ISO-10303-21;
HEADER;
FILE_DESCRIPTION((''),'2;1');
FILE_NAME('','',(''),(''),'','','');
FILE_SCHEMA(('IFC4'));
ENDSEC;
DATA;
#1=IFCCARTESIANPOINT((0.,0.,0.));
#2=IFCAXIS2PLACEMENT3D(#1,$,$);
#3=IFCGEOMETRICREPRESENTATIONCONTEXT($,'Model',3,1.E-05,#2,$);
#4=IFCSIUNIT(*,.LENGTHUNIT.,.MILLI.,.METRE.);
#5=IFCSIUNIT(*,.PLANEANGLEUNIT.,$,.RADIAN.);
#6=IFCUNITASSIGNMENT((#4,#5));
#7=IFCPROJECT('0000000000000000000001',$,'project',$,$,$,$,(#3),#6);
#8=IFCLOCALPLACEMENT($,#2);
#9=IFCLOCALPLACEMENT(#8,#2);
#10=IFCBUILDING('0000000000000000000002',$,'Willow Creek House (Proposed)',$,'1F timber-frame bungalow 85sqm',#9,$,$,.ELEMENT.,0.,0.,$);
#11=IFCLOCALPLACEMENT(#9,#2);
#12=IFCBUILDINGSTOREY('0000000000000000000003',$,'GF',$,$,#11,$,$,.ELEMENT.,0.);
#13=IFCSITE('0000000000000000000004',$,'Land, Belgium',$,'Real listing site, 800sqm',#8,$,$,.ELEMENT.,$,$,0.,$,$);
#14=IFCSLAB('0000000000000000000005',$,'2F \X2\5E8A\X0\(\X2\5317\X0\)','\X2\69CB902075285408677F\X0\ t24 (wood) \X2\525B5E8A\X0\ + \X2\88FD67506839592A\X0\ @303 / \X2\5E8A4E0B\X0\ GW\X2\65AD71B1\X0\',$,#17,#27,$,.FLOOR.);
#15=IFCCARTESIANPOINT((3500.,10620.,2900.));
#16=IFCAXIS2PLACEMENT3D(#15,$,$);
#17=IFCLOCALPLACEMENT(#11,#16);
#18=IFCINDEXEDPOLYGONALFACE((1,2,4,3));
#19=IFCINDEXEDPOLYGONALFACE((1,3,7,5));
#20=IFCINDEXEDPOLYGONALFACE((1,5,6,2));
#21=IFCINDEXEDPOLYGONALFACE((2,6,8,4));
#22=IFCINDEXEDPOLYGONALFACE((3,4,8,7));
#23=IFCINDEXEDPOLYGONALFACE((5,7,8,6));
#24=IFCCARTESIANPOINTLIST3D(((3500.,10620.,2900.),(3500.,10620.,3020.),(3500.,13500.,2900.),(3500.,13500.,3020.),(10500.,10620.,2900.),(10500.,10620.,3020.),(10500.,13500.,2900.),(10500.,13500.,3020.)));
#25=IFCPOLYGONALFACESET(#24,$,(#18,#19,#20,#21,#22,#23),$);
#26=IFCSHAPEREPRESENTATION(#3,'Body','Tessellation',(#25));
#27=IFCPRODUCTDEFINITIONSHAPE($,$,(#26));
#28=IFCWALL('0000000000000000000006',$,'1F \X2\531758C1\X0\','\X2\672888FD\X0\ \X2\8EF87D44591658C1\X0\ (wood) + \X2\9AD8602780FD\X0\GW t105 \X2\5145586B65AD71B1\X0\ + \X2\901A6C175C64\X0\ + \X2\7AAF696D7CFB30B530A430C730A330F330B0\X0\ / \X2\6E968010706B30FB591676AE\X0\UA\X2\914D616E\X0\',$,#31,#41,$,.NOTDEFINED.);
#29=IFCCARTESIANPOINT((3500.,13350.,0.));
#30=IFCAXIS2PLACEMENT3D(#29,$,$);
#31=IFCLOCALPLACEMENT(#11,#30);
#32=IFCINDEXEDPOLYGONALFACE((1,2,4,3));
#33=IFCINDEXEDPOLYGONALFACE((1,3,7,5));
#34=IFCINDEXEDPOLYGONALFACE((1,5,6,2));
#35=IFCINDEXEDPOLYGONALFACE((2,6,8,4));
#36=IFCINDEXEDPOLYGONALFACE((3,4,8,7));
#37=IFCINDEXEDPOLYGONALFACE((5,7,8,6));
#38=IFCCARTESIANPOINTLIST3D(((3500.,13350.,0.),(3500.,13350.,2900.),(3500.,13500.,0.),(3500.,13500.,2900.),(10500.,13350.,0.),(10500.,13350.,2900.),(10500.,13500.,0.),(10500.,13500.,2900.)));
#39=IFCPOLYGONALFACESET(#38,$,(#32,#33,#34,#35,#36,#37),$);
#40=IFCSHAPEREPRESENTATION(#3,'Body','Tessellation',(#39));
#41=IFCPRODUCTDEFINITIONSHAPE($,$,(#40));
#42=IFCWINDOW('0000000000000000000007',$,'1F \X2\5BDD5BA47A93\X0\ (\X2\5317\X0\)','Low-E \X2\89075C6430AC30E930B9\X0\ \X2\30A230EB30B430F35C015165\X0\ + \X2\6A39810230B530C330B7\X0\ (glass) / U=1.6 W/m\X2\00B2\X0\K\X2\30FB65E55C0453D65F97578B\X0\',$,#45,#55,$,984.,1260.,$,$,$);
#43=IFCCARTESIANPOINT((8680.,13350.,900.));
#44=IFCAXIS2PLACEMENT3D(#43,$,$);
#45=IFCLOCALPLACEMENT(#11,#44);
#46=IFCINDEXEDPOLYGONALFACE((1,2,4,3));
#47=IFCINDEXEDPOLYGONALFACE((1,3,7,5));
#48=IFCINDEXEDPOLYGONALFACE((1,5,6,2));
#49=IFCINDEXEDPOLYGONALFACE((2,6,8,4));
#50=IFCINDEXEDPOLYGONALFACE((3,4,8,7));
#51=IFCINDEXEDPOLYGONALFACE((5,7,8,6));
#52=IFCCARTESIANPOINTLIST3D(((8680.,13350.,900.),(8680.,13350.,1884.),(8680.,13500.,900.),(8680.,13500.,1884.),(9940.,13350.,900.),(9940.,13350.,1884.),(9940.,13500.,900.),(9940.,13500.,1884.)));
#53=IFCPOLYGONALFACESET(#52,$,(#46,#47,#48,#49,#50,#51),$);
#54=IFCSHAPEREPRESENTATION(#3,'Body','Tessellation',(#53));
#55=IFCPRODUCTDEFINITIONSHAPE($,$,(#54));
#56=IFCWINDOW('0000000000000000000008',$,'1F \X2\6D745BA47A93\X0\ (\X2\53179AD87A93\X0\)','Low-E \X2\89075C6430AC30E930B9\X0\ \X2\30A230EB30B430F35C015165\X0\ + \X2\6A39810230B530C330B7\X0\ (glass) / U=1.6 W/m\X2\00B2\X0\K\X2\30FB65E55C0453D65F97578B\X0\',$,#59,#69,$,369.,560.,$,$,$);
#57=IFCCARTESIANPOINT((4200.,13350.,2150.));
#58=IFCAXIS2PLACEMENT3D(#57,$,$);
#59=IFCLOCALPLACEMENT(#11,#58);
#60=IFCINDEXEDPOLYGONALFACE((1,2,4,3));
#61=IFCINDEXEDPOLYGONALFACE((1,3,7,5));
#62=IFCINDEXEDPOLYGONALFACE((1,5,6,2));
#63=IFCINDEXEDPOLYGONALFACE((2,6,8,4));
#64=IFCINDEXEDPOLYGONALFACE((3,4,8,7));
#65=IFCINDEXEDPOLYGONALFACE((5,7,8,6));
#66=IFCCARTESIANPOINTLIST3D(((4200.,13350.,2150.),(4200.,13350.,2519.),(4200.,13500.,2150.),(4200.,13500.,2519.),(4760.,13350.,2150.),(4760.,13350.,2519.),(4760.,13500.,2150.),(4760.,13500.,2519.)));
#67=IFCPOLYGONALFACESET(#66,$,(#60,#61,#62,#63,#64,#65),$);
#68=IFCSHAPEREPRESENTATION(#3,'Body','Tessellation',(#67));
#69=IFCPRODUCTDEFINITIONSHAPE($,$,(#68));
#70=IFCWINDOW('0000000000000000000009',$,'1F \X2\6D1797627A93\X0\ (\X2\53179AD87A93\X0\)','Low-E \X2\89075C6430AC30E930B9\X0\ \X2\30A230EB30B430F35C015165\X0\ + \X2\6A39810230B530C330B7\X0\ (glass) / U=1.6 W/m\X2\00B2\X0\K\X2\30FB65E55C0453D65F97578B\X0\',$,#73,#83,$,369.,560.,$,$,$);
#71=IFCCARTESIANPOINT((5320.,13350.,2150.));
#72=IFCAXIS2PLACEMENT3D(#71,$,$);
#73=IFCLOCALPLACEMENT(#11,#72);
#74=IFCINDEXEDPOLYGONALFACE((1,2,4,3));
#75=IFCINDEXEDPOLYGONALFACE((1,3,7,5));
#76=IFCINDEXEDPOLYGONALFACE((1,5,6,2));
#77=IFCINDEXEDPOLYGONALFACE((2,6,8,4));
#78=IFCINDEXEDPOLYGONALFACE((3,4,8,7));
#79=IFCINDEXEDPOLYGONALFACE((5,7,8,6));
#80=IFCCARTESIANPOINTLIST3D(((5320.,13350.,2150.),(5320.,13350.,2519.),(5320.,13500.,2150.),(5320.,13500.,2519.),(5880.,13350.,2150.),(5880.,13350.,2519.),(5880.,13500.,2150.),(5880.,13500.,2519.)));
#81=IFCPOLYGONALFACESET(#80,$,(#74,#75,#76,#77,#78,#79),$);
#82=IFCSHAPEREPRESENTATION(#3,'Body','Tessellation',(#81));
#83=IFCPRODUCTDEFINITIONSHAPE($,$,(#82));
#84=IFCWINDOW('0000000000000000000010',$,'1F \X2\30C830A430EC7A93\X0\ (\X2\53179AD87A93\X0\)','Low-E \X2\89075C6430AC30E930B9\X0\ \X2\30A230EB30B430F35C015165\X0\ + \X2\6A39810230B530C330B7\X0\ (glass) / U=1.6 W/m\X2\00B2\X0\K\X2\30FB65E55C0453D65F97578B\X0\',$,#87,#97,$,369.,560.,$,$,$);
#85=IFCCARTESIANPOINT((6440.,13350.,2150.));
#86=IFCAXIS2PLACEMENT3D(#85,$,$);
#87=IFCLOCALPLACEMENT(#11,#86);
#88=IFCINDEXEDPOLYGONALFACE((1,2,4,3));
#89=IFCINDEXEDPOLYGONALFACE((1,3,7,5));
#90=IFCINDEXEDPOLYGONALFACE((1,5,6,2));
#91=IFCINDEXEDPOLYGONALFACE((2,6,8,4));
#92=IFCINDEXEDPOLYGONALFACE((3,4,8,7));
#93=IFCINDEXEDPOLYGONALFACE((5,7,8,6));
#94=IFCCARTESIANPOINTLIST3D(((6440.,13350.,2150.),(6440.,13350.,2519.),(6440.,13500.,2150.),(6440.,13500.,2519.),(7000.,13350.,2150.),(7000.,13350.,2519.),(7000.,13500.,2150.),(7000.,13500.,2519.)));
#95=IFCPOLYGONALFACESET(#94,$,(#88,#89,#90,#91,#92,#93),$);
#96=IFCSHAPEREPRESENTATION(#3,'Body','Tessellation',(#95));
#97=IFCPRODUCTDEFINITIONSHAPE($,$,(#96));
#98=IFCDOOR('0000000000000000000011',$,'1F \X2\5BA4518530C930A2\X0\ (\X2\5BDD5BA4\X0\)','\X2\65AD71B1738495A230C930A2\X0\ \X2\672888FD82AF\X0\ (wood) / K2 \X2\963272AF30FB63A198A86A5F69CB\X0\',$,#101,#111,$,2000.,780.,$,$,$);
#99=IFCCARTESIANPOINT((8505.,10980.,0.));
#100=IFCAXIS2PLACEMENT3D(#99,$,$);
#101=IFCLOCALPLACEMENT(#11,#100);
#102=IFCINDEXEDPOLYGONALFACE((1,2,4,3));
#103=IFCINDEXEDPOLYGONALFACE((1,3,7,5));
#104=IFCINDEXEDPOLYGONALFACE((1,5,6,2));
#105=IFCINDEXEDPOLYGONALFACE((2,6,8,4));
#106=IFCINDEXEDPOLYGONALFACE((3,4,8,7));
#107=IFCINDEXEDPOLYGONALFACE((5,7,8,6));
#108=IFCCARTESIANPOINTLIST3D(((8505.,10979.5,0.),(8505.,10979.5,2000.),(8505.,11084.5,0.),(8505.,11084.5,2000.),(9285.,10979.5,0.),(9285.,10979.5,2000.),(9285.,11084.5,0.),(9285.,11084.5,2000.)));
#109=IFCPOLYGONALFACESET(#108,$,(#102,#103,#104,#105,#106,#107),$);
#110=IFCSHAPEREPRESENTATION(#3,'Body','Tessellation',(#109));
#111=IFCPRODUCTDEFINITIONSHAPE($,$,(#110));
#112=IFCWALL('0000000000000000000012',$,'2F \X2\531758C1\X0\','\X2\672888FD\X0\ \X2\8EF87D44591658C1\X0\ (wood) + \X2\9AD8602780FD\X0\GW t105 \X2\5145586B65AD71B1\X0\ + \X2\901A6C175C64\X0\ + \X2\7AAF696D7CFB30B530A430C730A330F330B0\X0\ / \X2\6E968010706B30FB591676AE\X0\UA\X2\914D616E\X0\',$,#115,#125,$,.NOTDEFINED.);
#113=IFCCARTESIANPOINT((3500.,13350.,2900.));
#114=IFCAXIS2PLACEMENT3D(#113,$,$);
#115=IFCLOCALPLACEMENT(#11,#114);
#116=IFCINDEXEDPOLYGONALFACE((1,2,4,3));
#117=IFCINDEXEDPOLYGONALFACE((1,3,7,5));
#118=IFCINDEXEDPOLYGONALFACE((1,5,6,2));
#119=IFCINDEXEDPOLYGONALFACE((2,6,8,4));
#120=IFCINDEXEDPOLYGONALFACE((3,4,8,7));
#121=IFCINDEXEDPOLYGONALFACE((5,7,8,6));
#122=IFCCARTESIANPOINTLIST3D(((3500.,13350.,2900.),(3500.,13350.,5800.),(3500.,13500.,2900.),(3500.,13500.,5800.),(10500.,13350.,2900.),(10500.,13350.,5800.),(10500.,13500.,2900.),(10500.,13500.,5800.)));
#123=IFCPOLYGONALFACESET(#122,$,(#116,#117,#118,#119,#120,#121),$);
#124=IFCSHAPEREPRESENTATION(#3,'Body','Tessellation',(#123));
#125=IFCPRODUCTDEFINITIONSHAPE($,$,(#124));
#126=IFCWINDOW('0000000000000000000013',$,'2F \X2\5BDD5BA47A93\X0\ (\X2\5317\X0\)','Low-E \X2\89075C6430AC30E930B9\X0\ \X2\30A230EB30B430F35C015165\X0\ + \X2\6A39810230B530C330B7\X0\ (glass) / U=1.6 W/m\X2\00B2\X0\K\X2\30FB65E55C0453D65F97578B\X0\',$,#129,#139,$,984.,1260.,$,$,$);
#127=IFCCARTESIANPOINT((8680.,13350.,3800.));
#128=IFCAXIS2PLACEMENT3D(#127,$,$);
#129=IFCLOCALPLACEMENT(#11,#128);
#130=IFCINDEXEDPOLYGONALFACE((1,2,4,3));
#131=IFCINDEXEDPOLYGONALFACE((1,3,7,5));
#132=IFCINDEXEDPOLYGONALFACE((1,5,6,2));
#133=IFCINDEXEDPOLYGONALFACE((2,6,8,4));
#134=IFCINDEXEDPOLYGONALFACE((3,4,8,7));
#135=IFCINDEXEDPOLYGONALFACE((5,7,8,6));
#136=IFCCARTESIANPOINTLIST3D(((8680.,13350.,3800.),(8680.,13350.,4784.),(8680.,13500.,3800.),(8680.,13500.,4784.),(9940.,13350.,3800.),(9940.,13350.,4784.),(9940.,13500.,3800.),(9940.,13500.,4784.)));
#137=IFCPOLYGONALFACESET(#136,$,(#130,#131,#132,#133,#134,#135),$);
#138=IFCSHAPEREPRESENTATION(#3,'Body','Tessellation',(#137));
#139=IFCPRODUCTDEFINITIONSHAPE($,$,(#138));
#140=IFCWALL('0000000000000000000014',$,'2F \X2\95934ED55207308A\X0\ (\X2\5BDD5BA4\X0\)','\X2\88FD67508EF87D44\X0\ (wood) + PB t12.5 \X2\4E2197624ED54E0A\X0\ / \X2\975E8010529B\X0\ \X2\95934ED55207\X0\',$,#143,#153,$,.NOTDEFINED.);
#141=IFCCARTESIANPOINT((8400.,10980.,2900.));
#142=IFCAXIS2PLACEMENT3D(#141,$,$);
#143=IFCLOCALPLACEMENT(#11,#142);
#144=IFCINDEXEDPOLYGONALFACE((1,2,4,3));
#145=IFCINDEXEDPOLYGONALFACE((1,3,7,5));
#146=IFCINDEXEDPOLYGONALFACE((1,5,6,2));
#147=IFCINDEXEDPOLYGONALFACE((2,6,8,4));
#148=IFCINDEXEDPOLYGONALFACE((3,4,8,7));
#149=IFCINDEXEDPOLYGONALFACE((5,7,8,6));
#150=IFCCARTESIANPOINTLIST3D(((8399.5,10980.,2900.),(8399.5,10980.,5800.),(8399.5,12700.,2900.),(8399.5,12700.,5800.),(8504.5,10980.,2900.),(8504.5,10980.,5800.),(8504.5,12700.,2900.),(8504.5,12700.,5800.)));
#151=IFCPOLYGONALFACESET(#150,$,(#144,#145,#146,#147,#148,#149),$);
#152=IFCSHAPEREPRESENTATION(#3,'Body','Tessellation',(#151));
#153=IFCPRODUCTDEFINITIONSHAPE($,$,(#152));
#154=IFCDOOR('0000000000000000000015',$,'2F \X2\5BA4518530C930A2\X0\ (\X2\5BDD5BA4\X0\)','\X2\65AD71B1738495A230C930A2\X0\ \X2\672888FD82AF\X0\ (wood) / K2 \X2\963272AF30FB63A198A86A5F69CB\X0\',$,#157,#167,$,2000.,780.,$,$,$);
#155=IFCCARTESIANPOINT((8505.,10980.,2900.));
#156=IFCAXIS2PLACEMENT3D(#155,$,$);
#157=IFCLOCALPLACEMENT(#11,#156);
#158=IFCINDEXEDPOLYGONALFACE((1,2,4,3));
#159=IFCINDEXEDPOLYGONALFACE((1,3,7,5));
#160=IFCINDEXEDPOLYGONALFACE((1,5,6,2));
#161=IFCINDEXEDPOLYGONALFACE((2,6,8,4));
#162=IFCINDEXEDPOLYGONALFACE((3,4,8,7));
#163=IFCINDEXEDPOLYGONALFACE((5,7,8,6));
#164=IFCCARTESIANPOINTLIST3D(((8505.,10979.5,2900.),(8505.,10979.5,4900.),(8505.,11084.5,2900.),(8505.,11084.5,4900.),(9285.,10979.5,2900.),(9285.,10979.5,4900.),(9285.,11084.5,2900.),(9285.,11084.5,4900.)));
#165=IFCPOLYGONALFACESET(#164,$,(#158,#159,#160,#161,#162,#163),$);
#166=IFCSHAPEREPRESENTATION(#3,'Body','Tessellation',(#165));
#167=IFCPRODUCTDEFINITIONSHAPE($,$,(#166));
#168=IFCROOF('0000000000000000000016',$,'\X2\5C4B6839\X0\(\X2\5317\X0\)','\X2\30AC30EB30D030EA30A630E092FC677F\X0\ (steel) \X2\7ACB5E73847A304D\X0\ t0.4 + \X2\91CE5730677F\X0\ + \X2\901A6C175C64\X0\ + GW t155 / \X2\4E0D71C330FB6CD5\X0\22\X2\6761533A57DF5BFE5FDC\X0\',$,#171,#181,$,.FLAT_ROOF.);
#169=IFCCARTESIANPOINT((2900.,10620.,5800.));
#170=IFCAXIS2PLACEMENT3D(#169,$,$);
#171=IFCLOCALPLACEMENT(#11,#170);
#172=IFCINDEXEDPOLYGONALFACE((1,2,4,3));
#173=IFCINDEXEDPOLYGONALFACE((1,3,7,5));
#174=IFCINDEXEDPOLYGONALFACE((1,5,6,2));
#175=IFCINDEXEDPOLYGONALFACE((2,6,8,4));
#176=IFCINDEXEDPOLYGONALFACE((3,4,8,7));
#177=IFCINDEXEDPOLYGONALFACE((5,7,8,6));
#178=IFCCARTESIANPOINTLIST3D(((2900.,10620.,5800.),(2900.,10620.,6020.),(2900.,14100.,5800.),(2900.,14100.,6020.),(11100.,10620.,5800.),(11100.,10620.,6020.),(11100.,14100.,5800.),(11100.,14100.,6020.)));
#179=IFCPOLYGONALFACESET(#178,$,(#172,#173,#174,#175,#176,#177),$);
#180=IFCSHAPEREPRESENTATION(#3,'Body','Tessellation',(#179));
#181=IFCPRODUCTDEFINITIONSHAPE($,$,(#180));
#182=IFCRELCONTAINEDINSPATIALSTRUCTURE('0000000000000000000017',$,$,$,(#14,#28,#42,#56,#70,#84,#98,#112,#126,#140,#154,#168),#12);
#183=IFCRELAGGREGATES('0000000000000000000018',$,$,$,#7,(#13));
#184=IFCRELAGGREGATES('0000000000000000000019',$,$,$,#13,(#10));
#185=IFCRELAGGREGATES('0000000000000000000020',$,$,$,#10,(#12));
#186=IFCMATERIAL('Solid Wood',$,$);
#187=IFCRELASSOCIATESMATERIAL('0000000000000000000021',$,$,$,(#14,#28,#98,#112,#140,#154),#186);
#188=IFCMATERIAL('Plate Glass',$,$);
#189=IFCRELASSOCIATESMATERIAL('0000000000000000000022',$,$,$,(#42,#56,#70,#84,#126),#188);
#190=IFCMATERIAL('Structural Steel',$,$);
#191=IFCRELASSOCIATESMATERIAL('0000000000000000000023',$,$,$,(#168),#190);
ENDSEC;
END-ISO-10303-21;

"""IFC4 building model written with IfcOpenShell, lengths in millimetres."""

from ifc_helpers import new_model, si_unit, frame, frame_2d, origin, place, context, project, spatial, rectangle, extrude, material, element, fill, save


model = new_model("IFC4")

# Units and contexts
model_context = context("Model", 3, precision=1e-05, world=origin())
ifc_project = project(units=[si_unit("LENGTHUNIT", "METRE", prefix="MILLI"), si_unit("PLANEANGLEUNIT", "RADIAN")], contexts=[model_context])

# Site, building, storey
site_placement = place(None, origin())
site = spatial("IfcSite", under=ifc_project, at=site_placement, Name="Land, Belgium", ObjectType="Real listing site, 800sqm", CompositionType="ELEMENT", RefElevation=0.0)
building_placement = place(site_placement, origin())
building = spatial("IfcBuilding", under=site, at=building_placement, Name="Willow Creek House (Proposed)", ObjectType="1F timber-frame bungalow 85sqm", CompositionType="ELEMENT", ElevationOfRefHeight=0.0, ElevationOfTerrain=0.0)
storey_placement = place(building_placement, origin())
storey = spatial("IfcBuildingStorey", under=building, at=storey_placement, Name="GF", CompositionType="ELEMENT", Elevation=0.0)

# Slab
ifc_material_1 = material(Name="Solid Wood")
slab_placement = place(storey_placement, frame((3500.0, 10620.0, 2900.0)))
element("IfcSlab", 1, at=slab_placement, inside=storey, material=ifc_material_1, Name="2F 床(北)", Description="構造用合板 t24 (wood) 剛床 + 製材根太 @303 / 床下 GW断熱", PredefinedType="FLOOR", context=model_context, shape_type="SweptSolid", body=[
    extrude(rectangle(XDim=7000.0, YDim=2880.0, at=frame_2d((3500.0, 1440.0))), frame((3500.0, 10620.0, 2900.0)), (0.0, 0.0, 1.0), 120.0),
])

# Wall, openings, windows
wall_1_placement = place(storey_placement, frame((3500.0, 13350.0, 0.0)))
wall_1 = element("IfcWall", 2, at=wall_1_placement, inside=storey, material=ifc_material_1, Name="1F 北壁", Description="木製 軸組外壁 (wood) + 高性能GW t105 充填断熱 + 通気層 + 窯業系サイディング / 準耐火・外皮UA配慮", PredefinedType="NOTDEFINED", context=model_context, shape_type="SweptSolid", body=[
    extrude(rectangle(XDim=7000.0, YDim=150.0, at=frame_2d((3500.0, 75.0))), frame((3500.0, 13350.0, 0.0)), (0.0, 0.0, 1.0), 2900.0),
])
opening_1_placement = place(storey_placement, frame((8680.0, 13350.0, 900.0)))
opening_1 = element("IfcOpeningElement", 3, at=opening_1_placement, cuts=wall_1, PredefinedType="NOTDEFINED", context=model_context, shape_type="SweptSolid", body=[
    extrude(rectangle(XDim=1260.0, YDim=150.0, at=frame_2d((630.0, 75.0))), frame((8680.0, 13350.0, 900.0)), (0.0, 0.0, 1.0), 984.0),
])
opening_2_placement = place(storey_placement, frame((4200.0, 13350.0, 2150.0)))
opening_2 = element("IfcOpeningElement", 4, at=opening_2_placement, cuts=wall_1, PredefinedType="NOTDEFINED", context=model_context, shape_type="SweptSolid", body=[
    extrude(rectangle(XDim=560.0, YDim=150.0, at=frame_2d((280.0, 75.0))), frame((4200.0, 13350.0, 2150.0)), (0.0, 0.0, 1.0), 369.0),
])
opening_3_placement = place(storey_placement, frame((5320.0, 13350.0, 2150.0)))
opening_3 = element("IfcOpeningElement", 5, at=opening_3_placement, cuts=wall_1, PredefinedType="NOTDEFINED", context=model_context, shape_type="SweptSolid", body=[
    extrude(rectangle(XDim=560.0, YDim=150.0, at=frame_2d((280.0, 75.0))), frame((5320.0, 13350.0, 2150.0)), (0.0, 0.0, 1.0), 369.0),
])
opening_4_placement = place(storey_placement, frame((6440.0, 13350.0, 2150.0)))
opening_4 = element("IfcOpeningElement", 6, at=opening_4_placement, cuts=wall_1, PredefinedType="NOTDEFINED", context=model_context, shape_type="SweptSolid", body=[
    extrude(rectangle(XDim=560.0, YDim=150.0, at=frame_2d((280.0, 75.0))), frame((6440.0, 13350.0, 2150.0)), (0.0, 0.0, 1.0), 369.0),
])
ifc_material_2 = material(Name="Plate Glass")
window_1_placement = place(storey_placement, frame((8680.0, 13350.0, 900.0)))
window_1 = element("IfcWindow", 7, at=window_1_placement, inside=storey, material=ifc_material_2, Name="1F 寝室窓 (北)", Description="Low-E 複層ガラス アルゴン封入 + 樹脂サッシ (glass) / U=1.6 W/m²K・日射取得型", OverallHeight=984.0, OverallWidth=1260.0, context=model_context, shape_type="SweptSolid", body=[
    extrude(rectangle(XDim=1260.0, YDim=150.0, at=frame_2d((630.0, 75.0))), frame((8680.0, 13350.0, 900.0)), (0.0, 0.0, 1.0), 984.0),
])
fill(opening_1, window_1)
window_2_placement = place(storey_placement, frame((4200.0, 13350.0, 2150.0)))
window_2 = element("IfcWindow", 8, at=window_2_placement, inside=storey, material=ifc_material_2, Name="1F 浴室窓 (北高窓)", Description="Low-E 複層ガラス アルゴン封入 + 樹脂サッシ (glass) / U=1.6 W/m²K・日射取得型", OverallHeight=369.0, OverallWidth=560.0, context=model_context, shape_type="SweptSolid", body=[
    extrude(rectangle(XDim=560.0, YDim=150.0, at=frame_2d((280.0, 75.0))), frame((4200.0, 13350.0, 2150.0)), (0.0, 0.0, 1.0), 369.0),
])
fill(opening_2, window_2)
window_3_placement = place(storey_placement, frame((5320.0, 13350.0, 2150.0)))
window_3 = element("IfcWindow", 9, at=window_3_placement, inside=storey, material=ifc_material_2, Name="1F 洗面窓 (北高窓)", Description="Low-E 複層ガラス アルゴン封入 + 樹脂サッシ (glass) / U=1.6 W/m²K・日射取得型", OverallHeight=369.0, OverallWidth=560.0, context=model_context, shape_type="SweptSolid", body=[
    extrude(rectangle(XDim=560.0, YDim=150.0, at=frame_2d((280.0, 75.0))), frame((5320.0, 13350.0, 2150.0)), (0.0, 0.0, 1.0), 369.0),
])
fill(opening_3, window_3)
window_4_placement = place(storey_placement, frame((6440.0, 13350.0, 2150.0)))
window_4 = element("IfcWindow", 10, at=window_4_placement, inside=storey, material=ifc_material_2, Name="1F トイレ窓 (北高窓)", Description="Low-E 複層ガラス アルゴン封入 + 樹脂サッシ (glass) / U=1.6 W/m²K・日射取得型", OverallHeight=369.0, OverallWidth=560.0, context=model_context, shape_type="SweptSolid", body=[
    extrude(rectangle(XDim=560.0, YDim=150.0, at=frame_2d((280.0, 75.0))), frame((6440.0, 13350.0, 2150.0)), (0.0, 0.0, 1.0), 369.0),
])
fill(opening_4, window_4)

# Door
door_1_placement = place(storey_placement, frame((8505.0, 10980.0, 0.0)))
element("IfcDoor", 11, at=door_1_placement, inside=storey, material=ifc_material_1, Name="1F 室内ドア (寝室)", Description="断熱玄関ドア 木製芯 (wood) / K2 防犯・採風機構", OverallHeight=2000.0, OverallWidth=780.0, context=model_context, shape_type="SweptSolid", body=[
    extrude(rectangle(XDim=780.0, YDim=105.0, at=frame_2d((390.0, 52.0))), frame((8505.0, 10980.0, 0.0)), (0.0, 0.0, 1.0), 2000.0),
])

# Wall, opening, window
wall_2_placement = place(storey_placement, frame((3500.0, 13350.0, 2900.0)))
wall_2 = element("IfcWall", 12, at=wall_2_placement, inside=storey, material=ifc_material_1, Name="2F 北壁", Description="木製 軸組外壁 (wood) + 高性能GW t105 充填断熱 + 通気層 + 窯業系サイディング / 準耐火・外皮UA配慮", PredefinedType="NOTDEFINED", context=model_context, shape_type="SweptSolid", body=[
    extrude(rectangle(XDim=7000.0, YDim=150.0, at=frame_2d((3500.0, 75.0))), frame((3500.0, 13350.0, 2900.0)), (0.0, 0.0, 1.0), 2900.0),
])
opening_5_placement = place(storey_placement, frame((8680.0, 13350.0, 3800.0)))
opening_5 = element("IfcOpeningElement", 13, at=opening_5_placement, cuts=wall_2, PredefinedType="NOTDEFINED", context=model_context, shape_type="SweptSolid", body=[
    extrude(rectangle(XDim=1260.0, YDim=150.0, at=frame_2d((630.0, 75.0))), frame((8680.0, 13350.0, 3800.0)), (0.0, 0.0, 1.0), 984.0),
])
window_5_placement = place(storey_placement, frame((8680.0, 13350.0, 3800.0)))
window_5 = element("IfcWindow", 14, at=window_5_placement, inside=storey, material=ifc_material_2, Name="2F 寝室窓 (北)", Description="Low-E 複層ガラス アルゴン封入 + 樹脂サッシ (glass) / U=1.6 W/m²K・日射取得型", OverallHeight=984.0, OverallWidth=1260.0, context=model_context, shape_type="SweptSolid", body=[
    extrude(rectangle(XDim=1260.0, YDim=150.0, at=frame_2d((630.0, 75.0))), frame((8680.0, 13350.0, 3800.0)), (0.0, 0.0, 1.0), 984.0),
])
fill(opening_5, window_5)

# Wall
wall_3_placement = place(storey_placement, frame((8400.0, 10980.0, 2900.0)))
element("IfcWall", 15, at=wall_3_placement, inside=storey, material=ifc_material_1, Name="2F 間仕切り (寝室)", Description="製材軸組 (wood) + PB t12.5 両面仕上 / 非耐力 間仕切", PredefinedType="NOTDEFINED", context=model_context, shape_type="SweptSolid", body=[
    extrude(rectangle(XDim=105.0, YDim=1720.0, at=frame_2d((52.0, 860.0))), frame((8400.0, 10980.0, 2900.0)), (0.0, 0.0, 1.0), 2900.0),
])

# Door
door_2_placement = place(storey_placement, frame((8505.0, 10980.0, 2900.0)))
element("IfcDoor", 16, at=door_2_placement, inside=storey, material=ifc_material_1, Name="2F 室内ドア (寝室)", Description="断熱玄関ドア 木製芯 (wood) / K2 防犯・採風機構", OverallHeight=2000.0, OverallWidth=780.0, context=model_context, shape_type="SweptSolid", body=[
    extrude(rectangle(XDim=780.0, YDim=105.0, at=frame_2d((390.0, 52.0))), frame((8505.0, 10980.0, 2900.0)), (0.0, 0.0, 1.0), 2000.0),
])

# Roof
ifc_material_3 = material(Name="Structural Steel")
roof_placement = place(storey_placement, frame((2900.0, 10620.0, 5800.0)))
element("IfcRoof", 17, at=roof_placement, inside=storey, material=ifc_material_3, Name="屋根(北)", Description="ガルバリウム鋼板 (steel) 立平葺き t0.4 + 野地板 + 通気層 + GW t155 / 不燃・法22条区域対応", PredefinedType="FLAT_ROOF", context=model_context, shape_type="SweptSolid", body=[
    extrude(rectangle(XDim=8200.0, YDim=3480.0, at=frame_2d((4100.0, 1740.0))), frame((2900.0, 10620.0, 5800.0)), (0.0, 0.0, 1.0), 220.0),
])

save(model, "model.ifc")
